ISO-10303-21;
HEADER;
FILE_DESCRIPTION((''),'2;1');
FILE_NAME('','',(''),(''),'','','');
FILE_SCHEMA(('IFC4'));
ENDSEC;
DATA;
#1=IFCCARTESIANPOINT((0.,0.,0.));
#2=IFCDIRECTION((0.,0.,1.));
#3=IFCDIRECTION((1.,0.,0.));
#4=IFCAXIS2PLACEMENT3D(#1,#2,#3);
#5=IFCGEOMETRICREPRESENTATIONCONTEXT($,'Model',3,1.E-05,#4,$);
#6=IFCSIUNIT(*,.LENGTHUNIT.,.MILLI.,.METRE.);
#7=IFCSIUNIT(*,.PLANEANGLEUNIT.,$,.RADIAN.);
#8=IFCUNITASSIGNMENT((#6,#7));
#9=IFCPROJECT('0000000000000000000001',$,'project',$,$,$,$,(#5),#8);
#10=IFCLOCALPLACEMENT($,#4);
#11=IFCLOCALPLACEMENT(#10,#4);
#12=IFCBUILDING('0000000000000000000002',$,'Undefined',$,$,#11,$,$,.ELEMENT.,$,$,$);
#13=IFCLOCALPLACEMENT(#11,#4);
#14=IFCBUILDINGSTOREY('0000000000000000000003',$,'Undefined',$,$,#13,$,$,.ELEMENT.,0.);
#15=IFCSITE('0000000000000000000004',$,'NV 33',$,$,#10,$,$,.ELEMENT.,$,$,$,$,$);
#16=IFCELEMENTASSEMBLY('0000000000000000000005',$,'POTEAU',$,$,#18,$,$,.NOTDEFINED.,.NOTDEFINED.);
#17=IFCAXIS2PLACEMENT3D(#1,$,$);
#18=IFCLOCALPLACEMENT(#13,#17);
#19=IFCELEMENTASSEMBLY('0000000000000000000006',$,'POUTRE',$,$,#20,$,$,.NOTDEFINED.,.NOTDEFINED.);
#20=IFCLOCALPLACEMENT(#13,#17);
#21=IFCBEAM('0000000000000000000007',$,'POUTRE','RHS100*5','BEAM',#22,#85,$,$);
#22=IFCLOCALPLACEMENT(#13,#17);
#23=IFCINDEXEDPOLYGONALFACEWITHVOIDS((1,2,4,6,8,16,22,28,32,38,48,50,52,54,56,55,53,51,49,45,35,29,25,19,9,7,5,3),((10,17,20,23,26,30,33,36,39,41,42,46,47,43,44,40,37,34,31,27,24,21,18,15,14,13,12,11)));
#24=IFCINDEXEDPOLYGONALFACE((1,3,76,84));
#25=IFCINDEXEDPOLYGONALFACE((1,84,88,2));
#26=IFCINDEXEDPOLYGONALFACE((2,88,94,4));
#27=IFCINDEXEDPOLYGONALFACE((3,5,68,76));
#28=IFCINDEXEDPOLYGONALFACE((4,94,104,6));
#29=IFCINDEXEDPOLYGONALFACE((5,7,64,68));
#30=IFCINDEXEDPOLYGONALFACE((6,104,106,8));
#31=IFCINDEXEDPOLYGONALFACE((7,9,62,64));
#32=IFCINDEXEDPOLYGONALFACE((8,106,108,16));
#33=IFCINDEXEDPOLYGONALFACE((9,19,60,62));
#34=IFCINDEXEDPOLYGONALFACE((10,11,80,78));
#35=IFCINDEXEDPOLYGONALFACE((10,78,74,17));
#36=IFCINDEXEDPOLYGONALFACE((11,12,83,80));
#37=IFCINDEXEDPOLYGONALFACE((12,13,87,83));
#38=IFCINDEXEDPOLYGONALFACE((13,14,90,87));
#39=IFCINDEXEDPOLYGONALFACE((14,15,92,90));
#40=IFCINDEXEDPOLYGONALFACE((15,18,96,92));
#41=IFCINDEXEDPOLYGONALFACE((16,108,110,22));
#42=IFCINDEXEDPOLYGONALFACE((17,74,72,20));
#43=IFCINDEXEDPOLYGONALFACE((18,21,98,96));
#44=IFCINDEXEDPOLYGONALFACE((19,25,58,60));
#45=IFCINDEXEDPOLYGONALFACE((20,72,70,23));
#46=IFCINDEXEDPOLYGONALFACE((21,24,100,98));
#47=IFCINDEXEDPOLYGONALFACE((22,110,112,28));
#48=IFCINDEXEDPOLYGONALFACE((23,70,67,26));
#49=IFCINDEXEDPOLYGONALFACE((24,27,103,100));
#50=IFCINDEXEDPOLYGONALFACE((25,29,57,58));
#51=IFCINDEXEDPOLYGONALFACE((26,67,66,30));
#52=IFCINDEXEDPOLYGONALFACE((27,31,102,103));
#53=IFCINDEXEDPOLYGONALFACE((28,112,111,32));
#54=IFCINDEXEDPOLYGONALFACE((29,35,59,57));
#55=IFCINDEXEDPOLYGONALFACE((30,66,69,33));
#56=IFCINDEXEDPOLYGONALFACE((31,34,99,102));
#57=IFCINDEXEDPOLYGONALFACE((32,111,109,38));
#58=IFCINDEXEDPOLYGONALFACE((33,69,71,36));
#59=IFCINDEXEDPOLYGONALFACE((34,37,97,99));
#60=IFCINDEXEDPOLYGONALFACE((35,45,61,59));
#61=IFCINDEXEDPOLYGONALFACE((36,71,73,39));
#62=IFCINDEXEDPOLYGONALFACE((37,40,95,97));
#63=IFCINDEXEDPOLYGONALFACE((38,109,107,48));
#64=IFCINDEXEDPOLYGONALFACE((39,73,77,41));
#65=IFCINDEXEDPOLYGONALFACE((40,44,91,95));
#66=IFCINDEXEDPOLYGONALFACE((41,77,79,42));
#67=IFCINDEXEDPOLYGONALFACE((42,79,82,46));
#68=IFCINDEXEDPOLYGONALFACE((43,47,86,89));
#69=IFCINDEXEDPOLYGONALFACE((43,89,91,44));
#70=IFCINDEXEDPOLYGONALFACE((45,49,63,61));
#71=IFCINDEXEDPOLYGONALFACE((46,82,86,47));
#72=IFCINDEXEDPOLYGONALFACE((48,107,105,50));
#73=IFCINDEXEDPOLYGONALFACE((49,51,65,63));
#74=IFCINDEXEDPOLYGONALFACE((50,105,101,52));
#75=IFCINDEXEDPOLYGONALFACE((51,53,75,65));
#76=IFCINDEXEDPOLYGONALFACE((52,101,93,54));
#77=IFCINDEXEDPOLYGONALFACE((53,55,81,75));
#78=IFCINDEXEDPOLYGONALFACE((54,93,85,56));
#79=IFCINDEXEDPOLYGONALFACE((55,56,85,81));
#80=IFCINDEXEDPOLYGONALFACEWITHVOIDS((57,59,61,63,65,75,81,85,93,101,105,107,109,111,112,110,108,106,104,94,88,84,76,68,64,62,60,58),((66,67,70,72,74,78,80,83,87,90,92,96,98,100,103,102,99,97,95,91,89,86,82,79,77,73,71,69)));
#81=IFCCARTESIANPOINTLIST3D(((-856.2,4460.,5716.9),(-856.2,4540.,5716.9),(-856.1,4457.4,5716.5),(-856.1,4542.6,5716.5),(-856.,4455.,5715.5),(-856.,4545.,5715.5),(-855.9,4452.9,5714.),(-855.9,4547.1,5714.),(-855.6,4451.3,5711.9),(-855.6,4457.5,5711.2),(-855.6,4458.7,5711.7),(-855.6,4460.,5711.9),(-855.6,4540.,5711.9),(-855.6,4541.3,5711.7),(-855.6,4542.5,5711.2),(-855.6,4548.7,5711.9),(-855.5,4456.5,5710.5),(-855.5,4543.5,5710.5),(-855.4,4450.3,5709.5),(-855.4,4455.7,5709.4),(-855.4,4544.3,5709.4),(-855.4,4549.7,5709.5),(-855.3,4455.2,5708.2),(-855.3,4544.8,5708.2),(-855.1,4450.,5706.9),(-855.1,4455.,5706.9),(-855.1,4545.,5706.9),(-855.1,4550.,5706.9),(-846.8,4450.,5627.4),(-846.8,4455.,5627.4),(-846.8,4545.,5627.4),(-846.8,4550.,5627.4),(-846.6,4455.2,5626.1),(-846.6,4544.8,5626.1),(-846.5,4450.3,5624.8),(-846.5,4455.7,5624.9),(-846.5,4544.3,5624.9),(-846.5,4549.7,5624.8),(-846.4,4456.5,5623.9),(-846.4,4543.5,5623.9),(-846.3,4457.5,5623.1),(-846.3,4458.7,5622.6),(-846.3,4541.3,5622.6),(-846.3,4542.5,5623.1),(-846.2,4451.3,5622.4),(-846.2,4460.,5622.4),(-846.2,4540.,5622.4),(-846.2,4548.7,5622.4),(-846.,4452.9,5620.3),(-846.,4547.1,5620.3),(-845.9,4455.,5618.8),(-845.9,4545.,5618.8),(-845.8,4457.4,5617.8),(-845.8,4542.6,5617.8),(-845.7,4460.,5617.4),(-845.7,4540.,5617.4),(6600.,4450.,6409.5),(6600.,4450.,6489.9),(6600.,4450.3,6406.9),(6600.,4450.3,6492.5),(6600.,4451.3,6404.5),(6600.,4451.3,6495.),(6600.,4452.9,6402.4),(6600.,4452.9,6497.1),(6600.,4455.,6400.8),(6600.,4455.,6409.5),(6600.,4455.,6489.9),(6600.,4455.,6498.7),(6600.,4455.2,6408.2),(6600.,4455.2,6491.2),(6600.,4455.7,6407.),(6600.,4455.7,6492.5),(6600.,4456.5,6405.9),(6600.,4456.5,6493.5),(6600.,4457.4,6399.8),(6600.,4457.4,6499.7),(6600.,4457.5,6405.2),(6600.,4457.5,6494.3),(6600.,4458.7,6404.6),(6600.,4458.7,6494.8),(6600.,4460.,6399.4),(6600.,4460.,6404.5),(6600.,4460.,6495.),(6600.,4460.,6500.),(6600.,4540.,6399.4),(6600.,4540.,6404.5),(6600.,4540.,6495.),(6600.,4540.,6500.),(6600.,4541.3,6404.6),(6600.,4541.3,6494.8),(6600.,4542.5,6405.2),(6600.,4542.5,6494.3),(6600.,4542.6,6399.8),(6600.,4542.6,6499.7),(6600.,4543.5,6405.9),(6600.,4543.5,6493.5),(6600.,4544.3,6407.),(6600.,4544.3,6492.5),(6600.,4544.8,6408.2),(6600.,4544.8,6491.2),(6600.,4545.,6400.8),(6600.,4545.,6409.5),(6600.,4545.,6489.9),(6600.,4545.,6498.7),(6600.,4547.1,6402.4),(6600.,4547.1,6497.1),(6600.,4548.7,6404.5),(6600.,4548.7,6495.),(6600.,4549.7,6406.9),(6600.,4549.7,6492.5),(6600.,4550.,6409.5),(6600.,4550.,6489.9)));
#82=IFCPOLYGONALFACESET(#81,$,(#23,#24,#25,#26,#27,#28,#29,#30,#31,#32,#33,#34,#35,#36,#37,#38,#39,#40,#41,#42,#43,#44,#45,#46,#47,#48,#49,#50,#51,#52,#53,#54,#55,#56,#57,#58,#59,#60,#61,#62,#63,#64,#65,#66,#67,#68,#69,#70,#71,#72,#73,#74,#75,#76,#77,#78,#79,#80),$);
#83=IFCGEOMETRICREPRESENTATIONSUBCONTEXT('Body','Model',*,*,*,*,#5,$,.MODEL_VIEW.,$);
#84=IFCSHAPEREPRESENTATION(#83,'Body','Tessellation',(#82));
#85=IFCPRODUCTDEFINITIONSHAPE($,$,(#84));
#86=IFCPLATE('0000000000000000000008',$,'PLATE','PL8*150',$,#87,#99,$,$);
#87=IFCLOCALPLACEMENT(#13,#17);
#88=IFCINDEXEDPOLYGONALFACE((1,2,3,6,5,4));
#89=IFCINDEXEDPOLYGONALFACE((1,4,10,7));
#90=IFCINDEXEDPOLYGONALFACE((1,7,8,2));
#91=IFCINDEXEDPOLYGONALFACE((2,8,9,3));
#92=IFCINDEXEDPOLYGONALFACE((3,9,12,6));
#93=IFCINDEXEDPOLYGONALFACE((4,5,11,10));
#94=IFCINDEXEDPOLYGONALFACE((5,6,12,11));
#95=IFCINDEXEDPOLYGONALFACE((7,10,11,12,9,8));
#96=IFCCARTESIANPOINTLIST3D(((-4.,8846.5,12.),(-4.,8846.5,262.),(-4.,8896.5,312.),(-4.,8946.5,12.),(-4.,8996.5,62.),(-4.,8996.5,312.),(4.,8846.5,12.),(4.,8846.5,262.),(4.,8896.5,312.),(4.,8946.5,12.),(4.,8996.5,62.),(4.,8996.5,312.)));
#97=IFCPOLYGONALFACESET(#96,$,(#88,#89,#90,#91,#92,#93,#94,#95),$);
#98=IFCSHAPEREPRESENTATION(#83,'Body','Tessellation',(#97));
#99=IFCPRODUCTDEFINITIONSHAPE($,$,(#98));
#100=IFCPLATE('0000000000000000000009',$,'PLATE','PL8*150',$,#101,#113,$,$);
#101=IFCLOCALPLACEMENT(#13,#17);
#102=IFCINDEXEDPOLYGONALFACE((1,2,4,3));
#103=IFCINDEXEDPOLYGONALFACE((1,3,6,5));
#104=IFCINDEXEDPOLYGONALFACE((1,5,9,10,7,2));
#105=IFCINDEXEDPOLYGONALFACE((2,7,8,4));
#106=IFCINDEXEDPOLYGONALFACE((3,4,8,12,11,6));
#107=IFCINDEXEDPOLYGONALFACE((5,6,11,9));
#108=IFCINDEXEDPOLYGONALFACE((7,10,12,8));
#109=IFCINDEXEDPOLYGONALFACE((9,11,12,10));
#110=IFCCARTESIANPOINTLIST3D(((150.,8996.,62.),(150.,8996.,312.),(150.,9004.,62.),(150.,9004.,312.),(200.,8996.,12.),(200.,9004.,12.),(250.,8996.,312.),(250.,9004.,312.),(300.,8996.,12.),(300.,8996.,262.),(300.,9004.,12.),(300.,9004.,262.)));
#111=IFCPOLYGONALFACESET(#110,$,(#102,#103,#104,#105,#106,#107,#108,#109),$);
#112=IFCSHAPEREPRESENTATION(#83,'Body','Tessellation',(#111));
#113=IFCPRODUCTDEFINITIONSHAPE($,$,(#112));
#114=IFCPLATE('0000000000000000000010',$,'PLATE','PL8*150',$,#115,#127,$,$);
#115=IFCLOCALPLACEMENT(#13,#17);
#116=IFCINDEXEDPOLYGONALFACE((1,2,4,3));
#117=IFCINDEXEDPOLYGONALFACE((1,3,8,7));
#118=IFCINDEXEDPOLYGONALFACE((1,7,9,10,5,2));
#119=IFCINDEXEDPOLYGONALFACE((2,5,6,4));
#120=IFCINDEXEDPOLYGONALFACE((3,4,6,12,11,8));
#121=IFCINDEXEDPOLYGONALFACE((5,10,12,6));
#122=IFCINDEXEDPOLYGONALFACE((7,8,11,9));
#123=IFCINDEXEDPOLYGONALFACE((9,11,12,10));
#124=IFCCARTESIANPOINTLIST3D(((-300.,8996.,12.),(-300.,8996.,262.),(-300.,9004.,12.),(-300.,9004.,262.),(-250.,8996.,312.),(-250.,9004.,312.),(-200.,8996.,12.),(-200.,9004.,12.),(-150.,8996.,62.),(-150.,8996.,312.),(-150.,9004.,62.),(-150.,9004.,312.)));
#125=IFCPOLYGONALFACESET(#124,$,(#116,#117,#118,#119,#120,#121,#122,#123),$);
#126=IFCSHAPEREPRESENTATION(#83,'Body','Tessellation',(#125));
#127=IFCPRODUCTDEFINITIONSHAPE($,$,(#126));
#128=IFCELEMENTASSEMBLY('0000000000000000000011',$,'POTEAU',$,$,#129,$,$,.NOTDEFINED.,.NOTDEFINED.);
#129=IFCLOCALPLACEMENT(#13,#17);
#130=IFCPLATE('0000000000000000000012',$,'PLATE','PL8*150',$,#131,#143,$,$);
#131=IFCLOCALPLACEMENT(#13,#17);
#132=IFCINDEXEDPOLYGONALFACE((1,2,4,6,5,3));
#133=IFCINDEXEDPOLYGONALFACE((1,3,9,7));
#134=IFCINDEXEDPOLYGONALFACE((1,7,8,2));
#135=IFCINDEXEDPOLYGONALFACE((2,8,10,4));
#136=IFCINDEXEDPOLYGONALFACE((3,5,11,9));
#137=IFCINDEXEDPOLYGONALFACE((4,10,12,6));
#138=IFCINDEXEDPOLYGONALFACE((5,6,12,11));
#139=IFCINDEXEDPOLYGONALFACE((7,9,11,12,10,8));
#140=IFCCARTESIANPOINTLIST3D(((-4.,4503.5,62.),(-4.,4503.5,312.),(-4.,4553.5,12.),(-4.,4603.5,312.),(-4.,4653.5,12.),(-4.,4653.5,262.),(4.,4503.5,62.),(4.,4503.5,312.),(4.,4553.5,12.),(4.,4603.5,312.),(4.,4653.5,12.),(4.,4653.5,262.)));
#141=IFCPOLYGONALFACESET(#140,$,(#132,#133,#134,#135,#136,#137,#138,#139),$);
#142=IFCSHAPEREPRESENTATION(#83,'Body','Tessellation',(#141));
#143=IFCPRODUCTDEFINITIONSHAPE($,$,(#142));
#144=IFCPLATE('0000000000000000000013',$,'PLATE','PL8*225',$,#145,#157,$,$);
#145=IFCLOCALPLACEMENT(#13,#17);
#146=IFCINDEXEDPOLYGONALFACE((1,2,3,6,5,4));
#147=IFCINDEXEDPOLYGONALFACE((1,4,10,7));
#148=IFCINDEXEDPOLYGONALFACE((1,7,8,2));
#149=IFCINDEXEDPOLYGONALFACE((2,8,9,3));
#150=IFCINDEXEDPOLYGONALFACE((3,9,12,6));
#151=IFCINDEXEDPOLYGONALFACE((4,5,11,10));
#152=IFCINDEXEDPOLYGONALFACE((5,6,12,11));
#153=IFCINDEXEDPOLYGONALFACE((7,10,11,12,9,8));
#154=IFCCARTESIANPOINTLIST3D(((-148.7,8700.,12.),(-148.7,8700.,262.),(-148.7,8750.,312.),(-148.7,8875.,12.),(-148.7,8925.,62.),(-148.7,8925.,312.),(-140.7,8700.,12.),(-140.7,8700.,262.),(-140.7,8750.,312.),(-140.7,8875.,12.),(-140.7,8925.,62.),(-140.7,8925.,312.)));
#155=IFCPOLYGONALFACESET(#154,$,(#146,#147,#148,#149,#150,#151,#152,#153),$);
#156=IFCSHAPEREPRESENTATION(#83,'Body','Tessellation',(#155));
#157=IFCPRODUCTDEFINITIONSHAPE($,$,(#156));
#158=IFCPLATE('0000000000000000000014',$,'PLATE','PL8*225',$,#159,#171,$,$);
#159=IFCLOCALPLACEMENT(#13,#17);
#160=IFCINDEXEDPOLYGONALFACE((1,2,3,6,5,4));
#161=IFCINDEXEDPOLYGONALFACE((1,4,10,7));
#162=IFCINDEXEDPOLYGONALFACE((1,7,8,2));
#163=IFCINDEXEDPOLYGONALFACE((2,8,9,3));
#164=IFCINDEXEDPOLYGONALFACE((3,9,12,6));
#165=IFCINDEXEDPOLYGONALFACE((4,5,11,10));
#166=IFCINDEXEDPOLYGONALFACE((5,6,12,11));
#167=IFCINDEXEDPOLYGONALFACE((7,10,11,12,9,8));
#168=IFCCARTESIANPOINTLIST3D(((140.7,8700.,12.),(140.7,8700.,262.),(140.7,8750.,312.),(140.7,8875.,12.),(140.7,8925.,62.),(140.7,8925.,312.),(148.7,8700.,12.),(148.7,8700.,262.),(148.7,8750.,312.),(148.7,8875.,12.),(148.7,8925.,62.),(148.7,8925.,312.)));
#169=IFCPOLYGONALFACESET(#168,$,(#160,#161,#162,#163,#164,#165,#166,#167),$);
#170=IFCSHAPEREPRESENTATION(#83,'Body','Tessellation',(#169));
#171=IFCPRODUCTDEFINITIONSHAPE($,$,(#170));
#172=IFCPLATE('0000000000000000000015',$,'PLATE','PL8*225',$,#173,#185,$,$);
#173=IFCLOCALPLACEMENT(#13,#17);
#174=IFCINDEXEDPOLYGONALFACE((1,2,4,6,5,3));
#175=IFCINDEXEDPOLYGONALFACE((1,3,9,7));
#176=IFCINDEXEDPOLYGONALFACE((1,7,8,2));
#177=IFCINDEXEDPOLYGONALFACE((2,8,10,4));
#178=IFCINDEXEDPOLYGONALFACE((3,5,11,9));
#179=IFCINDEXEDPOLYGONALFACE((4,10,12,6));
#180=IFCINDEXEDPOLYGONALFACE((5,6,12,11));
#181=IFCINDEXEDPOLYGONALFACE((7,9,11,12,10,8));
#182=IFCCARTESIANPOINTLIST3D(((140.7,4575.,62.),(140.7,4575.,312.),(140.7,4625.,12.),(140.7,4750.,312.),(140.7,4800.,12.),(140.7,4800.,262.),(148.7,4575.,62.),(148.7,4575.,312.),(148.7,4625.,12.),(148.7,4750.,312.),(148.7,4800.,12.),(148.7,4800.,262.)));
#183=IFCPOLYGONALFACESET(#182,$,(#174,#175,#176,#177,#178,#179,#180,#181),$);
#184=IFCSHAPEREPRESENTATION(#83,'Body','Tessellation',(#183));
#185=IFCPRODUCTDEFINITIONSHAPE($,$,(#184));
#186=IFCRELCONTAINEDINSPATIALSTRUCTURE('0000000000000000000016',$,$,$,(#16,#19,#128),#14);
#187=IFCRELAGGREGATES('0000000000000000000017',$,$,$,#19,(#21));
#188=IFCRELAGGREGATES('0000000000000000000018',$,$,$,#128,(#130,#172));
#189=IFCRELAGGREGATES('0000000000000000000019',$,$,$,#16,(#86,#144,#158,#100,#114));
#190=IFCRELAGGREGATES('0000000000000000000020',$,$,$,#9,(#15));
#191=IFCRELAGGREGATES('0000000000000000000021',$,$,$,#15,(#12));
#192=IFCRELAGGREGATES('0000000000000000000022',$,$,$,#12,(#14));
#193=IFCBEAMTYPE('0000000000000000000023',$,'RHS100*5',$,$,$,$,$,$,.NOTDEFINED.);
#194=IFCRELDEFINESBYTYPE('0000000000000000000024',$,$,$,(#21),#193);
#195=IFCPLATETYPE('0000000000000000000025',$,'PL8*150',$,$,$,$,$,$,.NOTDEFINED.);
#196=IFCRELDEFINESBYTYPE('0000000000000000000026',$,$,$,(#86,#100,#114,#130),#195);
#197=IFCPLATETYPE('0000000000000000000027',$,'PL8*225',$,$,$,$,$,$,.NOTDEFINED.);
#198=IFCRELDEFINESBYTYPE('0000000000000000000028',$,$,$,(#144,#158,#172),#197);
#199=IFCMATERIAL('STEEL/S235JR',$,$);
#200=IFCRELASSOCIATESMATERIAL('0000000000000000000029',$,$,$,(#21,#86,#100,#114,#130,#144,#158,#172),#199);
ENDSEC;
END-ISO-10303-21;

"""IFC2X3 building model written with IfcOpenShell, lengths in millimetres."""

from ifc_helpers import new_model, si_unit, frame, origin_with_axes, origin_2d_with_axis, place, context, subcontext, project, spatial, polyline, hollow_rectangle, outline, extrude, clip, halfspace, material, type_object, element, aggregate, save


model = new_model("IFC2X3")

# Units and contexts
model_context = context("Model", 3, precision=1e-05, world=origin_with_axes())
body_context = subcontext(model_context, "Body", "Model", "MODEL_VIEW")
ifc_project = project(units=[si_unit("LENGTHUNIT", "METRE", prefix="MILLI"), si_unit("PLANEANGLEUNIT", "RADIAN")], contexts=[model_context])

# Site, building, storey
site_placement = place(None, origin_with_axes())
site = spatial("IfcSite", under=ifc_project, at=site_placement, Name="NV 33", CompositionType="ELEMENT")
building_placement = place(site_placement, origin_with_axes())
building = spatial("IfcBuilding", under=site, at=building_placement, Name="Undefined", CompositionType="ELEMENT")
storey_placement = place(building_placement, origin_with_axes())
storey = spatial("IfcBuildingStorey", under=building, at=storey_placement, Name="Undefined", CompositionType="ELEMENT", Elevation=0.0)

# Element assembly
assembly_1_placement = place(storey_placement, origin_with_axes())
assembly_1 = element("IfcElementAssembly", 1, at=assembly_1_placement, inside=storey, Name="POTEAU", AssemblyPlace="NOTDEFINED", PredefinedType="NOTDEFINED")
ifc_material_1 = material(Name="STEEL/S235JR")

# Element assembly, beam
beam_type_1 = type_object("IfcBeamType", Name="RHS100*5", PredefinedType="NOTDEFINED")
assembly_2_placement = place(storey_placement, origin_with_axes())
assembly_2 = element("IfcElementAssembly", 2, at=assembly_2_placement, inside=storey, Name="POUTRE", AssemblyPlace="NOTDEFINED", PredefinedType="NOTDEFINED")
beam_1_placement = place(assembly_2_placement, frame((-850.9, 4500.0, 5667.2), z_axis=(0.104455, 0.0, -0.99453), x_axis=(0.99453, 0.0, 0.104455)))
beam_1 = element("IfcBeam", 3, at=beam_1_placement, type_object=beam_type_1, material=ifc_material_1, Name="POUTRE", Description="RHS100*5", ObjectType="BEAM", context=body_context, shape_type="Clipping", body=[
    clip(extrude(hollow_rectangle(XDim=100.0, YDim=100.0, WallThickness=5.0, InnerFilletRadius=5.0, OuterFilletRadius=10.0, at=origin_2d_with_axis()), frame((7527.2, 0.0, 0.0), z_axis=(-1.0, 0.0, 0.0), x_axis=(0.0, -1.0, 0.0)), (0.0, 0.0, 1.0), 7527.2), halfspace(frame((7497.2, -50.0, -50.0), z_axis=(0.99453, 0.0, 0.104455), x_axis=(-0.104455, 0.0, 0.99453)), False)),
])
aggregate(assembly_2, [beam_1])

# Plates
plate_type_1 = type_object("IfcPlateType", Name="PL8*150", PredefinedType="NOTDEFINED")
plate_1_placement = place(assembly_1_placement, frame((0.0, 8996.5, 12.0), z_axis=(-1.0, 0.0, 0.0), x_axis=(0.0, -1.0, 0.0)))
plate_1 = element("IfcPlate", 4, at=plate_1_placement, type_object=plate_type_1, material=ifc_material_1, Name="PLATE", Description="PL8*150", context=body_context, shape_type="SweptSolid", body=[
    extrude(outline(polyline([(0.0, 50.0), (50.0, 0.0), (150.0, 0.0), (150.0, 250.0), (100.0, 300.0), (0.0, 300.0), (0.0, 50.0)])), frame((0.0, 0.0, -4.0), z_axis=(0.0, 0.0, 1.0), x_axis=(1.0, 0.0, 0.0)), (0.0, 0.0, 1.0), 8.0),
])
plate_2_placement = place(assembly_1_placement, frame((150.0, 9000.0, 12.0), z_axis=(0.0, -1.0, 0.0), x_axis=(1.0, 0.0, 0.0)))
plate_2 = element("IfcPlate", 5, at=plate_2_placement, type_object=plate_type_1, material=ifc_material_1, Name="PLATE", Description="PL8*150", context=body_context, shape_type="SweptSolid", body=[
    extrude(outline(polyline([(0.0, 50.0), (50.0, 0.0), (150.0, 0.0), (150.0, 250.0), (100.0, 300.0), (0.0, 300.0), (0.0, 50.0)])), frame((0.0, 0.0, -4.0), z_axis=(0.0, 0.0, 1.0), x_axis=(1.0, 0.0, 0.0)), (0.0, 0.0, 1.0), 8.0),
])
plate_3_placement = place(assembly_1_placement, frame((-150.0, 9000.0, 12.0), z_axis=(0.0, 1.0, 0.0), x_axis=(-1.0, 0.0, 0.0)))
plate_3 = element("IfcPlate", 6, at=plate_3_placement, type_object=plate_type_1, material=ifc_material_1, Name="PLATE", Description="PL8*150", context=body_context, shape_type="SweptSolid", body=[
    extrude(outline(polyline([(0.0, 50.0), (50.0, 0.0), (150.0, 0.0), (150.0, 250.0), (100.0, 300.0), (0.0, 300.0), (0.0, 50.0)])), frame((0.0, 0.0, -4.0), z_axis=(0.0, 0.0, 1.0), x_axis=(1.0, 0.0, 0.0)), (0.0, 0.0, 1.0), 8.0),
])

# Element assembly, plate
assembly_3_placement = place(storey_placement, origin_with_axes())
assembly_3 = element("IfcElementAssembly", 7, at=assembly_3_placement, inside=storey, Name="POTEAU", AssemblyPlace="NOTDEFINED", PredefinedType="NOTDEFINED")
plate_4_placement = place(assembly_3_placement, frame((0.0, 4503.5, 12.0), z_axis=(1.0, 0.0, 0.0), x_axis=(0.0, 1.0, 0.0)))
plate_4 = element("IfcPlate", 8, at=plate_4_placement, type_object=plate_type_1, material=ifc_material_1, Name="PLATE", Description="PL8*150", context=body_context, shape_type="SweptSolid", body=[
    extrude(outline(polyline([(0.0, 50.0), (50.0, 0.0), (150.0, 0.0), (150.0, 250.0), (100.0, 300.0), (0.0, 300.0), (0.0, 50.0)])), frame((0.0, 0.0, -4.0), z_axis=(0.0, 0.0, 1.0), x_axis=(1.0, 0.0, 0.0)), (0.0, 0.0, 1.0), 8.0),
])

# Plates
plate_type_2 = type_object("IfcPlateType", Name="PL8*225", PredefinedType="NOTDEFINED")
plate_5_placement = place(assembly_1_placement, frame((-144.7, 8925.0, 12.0), z_axis=(-1.0, 0.0, 0.0), x_axis=(0.0, -1.0, 0.0)))
plate_5 = element("IfcPlate", 9, at=plate_5_placement, type_object=plate_type_2, material=ifc_material_1, Name="PLATE", Description="PL8*225", context=body_context, shape_type="SweptSolid", body=[
    extrude(outline(polyline([(0.0, 50.0), (50.0, 0.0), (225.0, 0.0), (225.0, 250.0), (175.0, 300.0), (0.0, 300.0), (0.0, 50.0)])), frame((0.0, 0.0, -4.0), z_axis=(0.0, 0.0, 1.0), x_axis=(1.0, 0.0, 0.0)), (0.0, 0.0, 1.0), 8.0),
])
plate_6_placement = place(assembly_1_placement, frame((144.7, 8925.0, 12.0), z_axis=(-1.0, 0.0, 0.0), x_axis=(0.0, -1.0, 0.0)))
plate_6 = element("IfcPlate", 10, at=plate_6_placement, type_object=plate_type_2, material=ifc_material_1, Name="PLATE", Description="PL8*225", context=body_context, shape_type="SweptSolid", body=[
    extrude(outline(polyline([(0.0, 50.0), (50.0, 0.0), (225.0, 0.0), (225.0, 250.0), (175.0, 300.0), (0.0, 300.0), (0.0, 50.0)])), frame((0.0, 0.0, -4.0), z_axis=(0.0, 0.0, 1.0), x_axis=(1.0, 0.0, 0.0)), (0.0, 0.0, 1.0), 8.0),
])
plate_7_placement = place(assembly_3_placement, frame((144.7, 4575.0, 12.0), z_axis=(1.0, 0.0, 0.0), x_axis=(0.0, 1.0, 0.0)))
plate_7 = element("IfcPlate", 11, at=plate_7_placement, type_object=plate_type_2, material=ifc_material_1, Name="PLATE", Description="PL8*225", context=body_context, shape_type="SweptSolid", body=[
    extrude(outline(polyline([(0.0, 50.0), (50.0, 0.0), (225.0, 0.0), (225.0, 250.0), (175.0, 300.0), (0.0, 300.0), (0.0, 50.0)])), frame((0.0, 0.0, -4.0), z_axis=(0.0, 0.0, 1.0), x_axis=(1.0, 0.0, 0.0)), (0.0, 0.0, 1.0), 8.0),
])
aggregate(assembly_3, [plate_4, plate_7])

aggregate(assembly_1, [plate_1, plate_5, plate_6, plate_2, plate_3])

save(model, "model.ifc")
